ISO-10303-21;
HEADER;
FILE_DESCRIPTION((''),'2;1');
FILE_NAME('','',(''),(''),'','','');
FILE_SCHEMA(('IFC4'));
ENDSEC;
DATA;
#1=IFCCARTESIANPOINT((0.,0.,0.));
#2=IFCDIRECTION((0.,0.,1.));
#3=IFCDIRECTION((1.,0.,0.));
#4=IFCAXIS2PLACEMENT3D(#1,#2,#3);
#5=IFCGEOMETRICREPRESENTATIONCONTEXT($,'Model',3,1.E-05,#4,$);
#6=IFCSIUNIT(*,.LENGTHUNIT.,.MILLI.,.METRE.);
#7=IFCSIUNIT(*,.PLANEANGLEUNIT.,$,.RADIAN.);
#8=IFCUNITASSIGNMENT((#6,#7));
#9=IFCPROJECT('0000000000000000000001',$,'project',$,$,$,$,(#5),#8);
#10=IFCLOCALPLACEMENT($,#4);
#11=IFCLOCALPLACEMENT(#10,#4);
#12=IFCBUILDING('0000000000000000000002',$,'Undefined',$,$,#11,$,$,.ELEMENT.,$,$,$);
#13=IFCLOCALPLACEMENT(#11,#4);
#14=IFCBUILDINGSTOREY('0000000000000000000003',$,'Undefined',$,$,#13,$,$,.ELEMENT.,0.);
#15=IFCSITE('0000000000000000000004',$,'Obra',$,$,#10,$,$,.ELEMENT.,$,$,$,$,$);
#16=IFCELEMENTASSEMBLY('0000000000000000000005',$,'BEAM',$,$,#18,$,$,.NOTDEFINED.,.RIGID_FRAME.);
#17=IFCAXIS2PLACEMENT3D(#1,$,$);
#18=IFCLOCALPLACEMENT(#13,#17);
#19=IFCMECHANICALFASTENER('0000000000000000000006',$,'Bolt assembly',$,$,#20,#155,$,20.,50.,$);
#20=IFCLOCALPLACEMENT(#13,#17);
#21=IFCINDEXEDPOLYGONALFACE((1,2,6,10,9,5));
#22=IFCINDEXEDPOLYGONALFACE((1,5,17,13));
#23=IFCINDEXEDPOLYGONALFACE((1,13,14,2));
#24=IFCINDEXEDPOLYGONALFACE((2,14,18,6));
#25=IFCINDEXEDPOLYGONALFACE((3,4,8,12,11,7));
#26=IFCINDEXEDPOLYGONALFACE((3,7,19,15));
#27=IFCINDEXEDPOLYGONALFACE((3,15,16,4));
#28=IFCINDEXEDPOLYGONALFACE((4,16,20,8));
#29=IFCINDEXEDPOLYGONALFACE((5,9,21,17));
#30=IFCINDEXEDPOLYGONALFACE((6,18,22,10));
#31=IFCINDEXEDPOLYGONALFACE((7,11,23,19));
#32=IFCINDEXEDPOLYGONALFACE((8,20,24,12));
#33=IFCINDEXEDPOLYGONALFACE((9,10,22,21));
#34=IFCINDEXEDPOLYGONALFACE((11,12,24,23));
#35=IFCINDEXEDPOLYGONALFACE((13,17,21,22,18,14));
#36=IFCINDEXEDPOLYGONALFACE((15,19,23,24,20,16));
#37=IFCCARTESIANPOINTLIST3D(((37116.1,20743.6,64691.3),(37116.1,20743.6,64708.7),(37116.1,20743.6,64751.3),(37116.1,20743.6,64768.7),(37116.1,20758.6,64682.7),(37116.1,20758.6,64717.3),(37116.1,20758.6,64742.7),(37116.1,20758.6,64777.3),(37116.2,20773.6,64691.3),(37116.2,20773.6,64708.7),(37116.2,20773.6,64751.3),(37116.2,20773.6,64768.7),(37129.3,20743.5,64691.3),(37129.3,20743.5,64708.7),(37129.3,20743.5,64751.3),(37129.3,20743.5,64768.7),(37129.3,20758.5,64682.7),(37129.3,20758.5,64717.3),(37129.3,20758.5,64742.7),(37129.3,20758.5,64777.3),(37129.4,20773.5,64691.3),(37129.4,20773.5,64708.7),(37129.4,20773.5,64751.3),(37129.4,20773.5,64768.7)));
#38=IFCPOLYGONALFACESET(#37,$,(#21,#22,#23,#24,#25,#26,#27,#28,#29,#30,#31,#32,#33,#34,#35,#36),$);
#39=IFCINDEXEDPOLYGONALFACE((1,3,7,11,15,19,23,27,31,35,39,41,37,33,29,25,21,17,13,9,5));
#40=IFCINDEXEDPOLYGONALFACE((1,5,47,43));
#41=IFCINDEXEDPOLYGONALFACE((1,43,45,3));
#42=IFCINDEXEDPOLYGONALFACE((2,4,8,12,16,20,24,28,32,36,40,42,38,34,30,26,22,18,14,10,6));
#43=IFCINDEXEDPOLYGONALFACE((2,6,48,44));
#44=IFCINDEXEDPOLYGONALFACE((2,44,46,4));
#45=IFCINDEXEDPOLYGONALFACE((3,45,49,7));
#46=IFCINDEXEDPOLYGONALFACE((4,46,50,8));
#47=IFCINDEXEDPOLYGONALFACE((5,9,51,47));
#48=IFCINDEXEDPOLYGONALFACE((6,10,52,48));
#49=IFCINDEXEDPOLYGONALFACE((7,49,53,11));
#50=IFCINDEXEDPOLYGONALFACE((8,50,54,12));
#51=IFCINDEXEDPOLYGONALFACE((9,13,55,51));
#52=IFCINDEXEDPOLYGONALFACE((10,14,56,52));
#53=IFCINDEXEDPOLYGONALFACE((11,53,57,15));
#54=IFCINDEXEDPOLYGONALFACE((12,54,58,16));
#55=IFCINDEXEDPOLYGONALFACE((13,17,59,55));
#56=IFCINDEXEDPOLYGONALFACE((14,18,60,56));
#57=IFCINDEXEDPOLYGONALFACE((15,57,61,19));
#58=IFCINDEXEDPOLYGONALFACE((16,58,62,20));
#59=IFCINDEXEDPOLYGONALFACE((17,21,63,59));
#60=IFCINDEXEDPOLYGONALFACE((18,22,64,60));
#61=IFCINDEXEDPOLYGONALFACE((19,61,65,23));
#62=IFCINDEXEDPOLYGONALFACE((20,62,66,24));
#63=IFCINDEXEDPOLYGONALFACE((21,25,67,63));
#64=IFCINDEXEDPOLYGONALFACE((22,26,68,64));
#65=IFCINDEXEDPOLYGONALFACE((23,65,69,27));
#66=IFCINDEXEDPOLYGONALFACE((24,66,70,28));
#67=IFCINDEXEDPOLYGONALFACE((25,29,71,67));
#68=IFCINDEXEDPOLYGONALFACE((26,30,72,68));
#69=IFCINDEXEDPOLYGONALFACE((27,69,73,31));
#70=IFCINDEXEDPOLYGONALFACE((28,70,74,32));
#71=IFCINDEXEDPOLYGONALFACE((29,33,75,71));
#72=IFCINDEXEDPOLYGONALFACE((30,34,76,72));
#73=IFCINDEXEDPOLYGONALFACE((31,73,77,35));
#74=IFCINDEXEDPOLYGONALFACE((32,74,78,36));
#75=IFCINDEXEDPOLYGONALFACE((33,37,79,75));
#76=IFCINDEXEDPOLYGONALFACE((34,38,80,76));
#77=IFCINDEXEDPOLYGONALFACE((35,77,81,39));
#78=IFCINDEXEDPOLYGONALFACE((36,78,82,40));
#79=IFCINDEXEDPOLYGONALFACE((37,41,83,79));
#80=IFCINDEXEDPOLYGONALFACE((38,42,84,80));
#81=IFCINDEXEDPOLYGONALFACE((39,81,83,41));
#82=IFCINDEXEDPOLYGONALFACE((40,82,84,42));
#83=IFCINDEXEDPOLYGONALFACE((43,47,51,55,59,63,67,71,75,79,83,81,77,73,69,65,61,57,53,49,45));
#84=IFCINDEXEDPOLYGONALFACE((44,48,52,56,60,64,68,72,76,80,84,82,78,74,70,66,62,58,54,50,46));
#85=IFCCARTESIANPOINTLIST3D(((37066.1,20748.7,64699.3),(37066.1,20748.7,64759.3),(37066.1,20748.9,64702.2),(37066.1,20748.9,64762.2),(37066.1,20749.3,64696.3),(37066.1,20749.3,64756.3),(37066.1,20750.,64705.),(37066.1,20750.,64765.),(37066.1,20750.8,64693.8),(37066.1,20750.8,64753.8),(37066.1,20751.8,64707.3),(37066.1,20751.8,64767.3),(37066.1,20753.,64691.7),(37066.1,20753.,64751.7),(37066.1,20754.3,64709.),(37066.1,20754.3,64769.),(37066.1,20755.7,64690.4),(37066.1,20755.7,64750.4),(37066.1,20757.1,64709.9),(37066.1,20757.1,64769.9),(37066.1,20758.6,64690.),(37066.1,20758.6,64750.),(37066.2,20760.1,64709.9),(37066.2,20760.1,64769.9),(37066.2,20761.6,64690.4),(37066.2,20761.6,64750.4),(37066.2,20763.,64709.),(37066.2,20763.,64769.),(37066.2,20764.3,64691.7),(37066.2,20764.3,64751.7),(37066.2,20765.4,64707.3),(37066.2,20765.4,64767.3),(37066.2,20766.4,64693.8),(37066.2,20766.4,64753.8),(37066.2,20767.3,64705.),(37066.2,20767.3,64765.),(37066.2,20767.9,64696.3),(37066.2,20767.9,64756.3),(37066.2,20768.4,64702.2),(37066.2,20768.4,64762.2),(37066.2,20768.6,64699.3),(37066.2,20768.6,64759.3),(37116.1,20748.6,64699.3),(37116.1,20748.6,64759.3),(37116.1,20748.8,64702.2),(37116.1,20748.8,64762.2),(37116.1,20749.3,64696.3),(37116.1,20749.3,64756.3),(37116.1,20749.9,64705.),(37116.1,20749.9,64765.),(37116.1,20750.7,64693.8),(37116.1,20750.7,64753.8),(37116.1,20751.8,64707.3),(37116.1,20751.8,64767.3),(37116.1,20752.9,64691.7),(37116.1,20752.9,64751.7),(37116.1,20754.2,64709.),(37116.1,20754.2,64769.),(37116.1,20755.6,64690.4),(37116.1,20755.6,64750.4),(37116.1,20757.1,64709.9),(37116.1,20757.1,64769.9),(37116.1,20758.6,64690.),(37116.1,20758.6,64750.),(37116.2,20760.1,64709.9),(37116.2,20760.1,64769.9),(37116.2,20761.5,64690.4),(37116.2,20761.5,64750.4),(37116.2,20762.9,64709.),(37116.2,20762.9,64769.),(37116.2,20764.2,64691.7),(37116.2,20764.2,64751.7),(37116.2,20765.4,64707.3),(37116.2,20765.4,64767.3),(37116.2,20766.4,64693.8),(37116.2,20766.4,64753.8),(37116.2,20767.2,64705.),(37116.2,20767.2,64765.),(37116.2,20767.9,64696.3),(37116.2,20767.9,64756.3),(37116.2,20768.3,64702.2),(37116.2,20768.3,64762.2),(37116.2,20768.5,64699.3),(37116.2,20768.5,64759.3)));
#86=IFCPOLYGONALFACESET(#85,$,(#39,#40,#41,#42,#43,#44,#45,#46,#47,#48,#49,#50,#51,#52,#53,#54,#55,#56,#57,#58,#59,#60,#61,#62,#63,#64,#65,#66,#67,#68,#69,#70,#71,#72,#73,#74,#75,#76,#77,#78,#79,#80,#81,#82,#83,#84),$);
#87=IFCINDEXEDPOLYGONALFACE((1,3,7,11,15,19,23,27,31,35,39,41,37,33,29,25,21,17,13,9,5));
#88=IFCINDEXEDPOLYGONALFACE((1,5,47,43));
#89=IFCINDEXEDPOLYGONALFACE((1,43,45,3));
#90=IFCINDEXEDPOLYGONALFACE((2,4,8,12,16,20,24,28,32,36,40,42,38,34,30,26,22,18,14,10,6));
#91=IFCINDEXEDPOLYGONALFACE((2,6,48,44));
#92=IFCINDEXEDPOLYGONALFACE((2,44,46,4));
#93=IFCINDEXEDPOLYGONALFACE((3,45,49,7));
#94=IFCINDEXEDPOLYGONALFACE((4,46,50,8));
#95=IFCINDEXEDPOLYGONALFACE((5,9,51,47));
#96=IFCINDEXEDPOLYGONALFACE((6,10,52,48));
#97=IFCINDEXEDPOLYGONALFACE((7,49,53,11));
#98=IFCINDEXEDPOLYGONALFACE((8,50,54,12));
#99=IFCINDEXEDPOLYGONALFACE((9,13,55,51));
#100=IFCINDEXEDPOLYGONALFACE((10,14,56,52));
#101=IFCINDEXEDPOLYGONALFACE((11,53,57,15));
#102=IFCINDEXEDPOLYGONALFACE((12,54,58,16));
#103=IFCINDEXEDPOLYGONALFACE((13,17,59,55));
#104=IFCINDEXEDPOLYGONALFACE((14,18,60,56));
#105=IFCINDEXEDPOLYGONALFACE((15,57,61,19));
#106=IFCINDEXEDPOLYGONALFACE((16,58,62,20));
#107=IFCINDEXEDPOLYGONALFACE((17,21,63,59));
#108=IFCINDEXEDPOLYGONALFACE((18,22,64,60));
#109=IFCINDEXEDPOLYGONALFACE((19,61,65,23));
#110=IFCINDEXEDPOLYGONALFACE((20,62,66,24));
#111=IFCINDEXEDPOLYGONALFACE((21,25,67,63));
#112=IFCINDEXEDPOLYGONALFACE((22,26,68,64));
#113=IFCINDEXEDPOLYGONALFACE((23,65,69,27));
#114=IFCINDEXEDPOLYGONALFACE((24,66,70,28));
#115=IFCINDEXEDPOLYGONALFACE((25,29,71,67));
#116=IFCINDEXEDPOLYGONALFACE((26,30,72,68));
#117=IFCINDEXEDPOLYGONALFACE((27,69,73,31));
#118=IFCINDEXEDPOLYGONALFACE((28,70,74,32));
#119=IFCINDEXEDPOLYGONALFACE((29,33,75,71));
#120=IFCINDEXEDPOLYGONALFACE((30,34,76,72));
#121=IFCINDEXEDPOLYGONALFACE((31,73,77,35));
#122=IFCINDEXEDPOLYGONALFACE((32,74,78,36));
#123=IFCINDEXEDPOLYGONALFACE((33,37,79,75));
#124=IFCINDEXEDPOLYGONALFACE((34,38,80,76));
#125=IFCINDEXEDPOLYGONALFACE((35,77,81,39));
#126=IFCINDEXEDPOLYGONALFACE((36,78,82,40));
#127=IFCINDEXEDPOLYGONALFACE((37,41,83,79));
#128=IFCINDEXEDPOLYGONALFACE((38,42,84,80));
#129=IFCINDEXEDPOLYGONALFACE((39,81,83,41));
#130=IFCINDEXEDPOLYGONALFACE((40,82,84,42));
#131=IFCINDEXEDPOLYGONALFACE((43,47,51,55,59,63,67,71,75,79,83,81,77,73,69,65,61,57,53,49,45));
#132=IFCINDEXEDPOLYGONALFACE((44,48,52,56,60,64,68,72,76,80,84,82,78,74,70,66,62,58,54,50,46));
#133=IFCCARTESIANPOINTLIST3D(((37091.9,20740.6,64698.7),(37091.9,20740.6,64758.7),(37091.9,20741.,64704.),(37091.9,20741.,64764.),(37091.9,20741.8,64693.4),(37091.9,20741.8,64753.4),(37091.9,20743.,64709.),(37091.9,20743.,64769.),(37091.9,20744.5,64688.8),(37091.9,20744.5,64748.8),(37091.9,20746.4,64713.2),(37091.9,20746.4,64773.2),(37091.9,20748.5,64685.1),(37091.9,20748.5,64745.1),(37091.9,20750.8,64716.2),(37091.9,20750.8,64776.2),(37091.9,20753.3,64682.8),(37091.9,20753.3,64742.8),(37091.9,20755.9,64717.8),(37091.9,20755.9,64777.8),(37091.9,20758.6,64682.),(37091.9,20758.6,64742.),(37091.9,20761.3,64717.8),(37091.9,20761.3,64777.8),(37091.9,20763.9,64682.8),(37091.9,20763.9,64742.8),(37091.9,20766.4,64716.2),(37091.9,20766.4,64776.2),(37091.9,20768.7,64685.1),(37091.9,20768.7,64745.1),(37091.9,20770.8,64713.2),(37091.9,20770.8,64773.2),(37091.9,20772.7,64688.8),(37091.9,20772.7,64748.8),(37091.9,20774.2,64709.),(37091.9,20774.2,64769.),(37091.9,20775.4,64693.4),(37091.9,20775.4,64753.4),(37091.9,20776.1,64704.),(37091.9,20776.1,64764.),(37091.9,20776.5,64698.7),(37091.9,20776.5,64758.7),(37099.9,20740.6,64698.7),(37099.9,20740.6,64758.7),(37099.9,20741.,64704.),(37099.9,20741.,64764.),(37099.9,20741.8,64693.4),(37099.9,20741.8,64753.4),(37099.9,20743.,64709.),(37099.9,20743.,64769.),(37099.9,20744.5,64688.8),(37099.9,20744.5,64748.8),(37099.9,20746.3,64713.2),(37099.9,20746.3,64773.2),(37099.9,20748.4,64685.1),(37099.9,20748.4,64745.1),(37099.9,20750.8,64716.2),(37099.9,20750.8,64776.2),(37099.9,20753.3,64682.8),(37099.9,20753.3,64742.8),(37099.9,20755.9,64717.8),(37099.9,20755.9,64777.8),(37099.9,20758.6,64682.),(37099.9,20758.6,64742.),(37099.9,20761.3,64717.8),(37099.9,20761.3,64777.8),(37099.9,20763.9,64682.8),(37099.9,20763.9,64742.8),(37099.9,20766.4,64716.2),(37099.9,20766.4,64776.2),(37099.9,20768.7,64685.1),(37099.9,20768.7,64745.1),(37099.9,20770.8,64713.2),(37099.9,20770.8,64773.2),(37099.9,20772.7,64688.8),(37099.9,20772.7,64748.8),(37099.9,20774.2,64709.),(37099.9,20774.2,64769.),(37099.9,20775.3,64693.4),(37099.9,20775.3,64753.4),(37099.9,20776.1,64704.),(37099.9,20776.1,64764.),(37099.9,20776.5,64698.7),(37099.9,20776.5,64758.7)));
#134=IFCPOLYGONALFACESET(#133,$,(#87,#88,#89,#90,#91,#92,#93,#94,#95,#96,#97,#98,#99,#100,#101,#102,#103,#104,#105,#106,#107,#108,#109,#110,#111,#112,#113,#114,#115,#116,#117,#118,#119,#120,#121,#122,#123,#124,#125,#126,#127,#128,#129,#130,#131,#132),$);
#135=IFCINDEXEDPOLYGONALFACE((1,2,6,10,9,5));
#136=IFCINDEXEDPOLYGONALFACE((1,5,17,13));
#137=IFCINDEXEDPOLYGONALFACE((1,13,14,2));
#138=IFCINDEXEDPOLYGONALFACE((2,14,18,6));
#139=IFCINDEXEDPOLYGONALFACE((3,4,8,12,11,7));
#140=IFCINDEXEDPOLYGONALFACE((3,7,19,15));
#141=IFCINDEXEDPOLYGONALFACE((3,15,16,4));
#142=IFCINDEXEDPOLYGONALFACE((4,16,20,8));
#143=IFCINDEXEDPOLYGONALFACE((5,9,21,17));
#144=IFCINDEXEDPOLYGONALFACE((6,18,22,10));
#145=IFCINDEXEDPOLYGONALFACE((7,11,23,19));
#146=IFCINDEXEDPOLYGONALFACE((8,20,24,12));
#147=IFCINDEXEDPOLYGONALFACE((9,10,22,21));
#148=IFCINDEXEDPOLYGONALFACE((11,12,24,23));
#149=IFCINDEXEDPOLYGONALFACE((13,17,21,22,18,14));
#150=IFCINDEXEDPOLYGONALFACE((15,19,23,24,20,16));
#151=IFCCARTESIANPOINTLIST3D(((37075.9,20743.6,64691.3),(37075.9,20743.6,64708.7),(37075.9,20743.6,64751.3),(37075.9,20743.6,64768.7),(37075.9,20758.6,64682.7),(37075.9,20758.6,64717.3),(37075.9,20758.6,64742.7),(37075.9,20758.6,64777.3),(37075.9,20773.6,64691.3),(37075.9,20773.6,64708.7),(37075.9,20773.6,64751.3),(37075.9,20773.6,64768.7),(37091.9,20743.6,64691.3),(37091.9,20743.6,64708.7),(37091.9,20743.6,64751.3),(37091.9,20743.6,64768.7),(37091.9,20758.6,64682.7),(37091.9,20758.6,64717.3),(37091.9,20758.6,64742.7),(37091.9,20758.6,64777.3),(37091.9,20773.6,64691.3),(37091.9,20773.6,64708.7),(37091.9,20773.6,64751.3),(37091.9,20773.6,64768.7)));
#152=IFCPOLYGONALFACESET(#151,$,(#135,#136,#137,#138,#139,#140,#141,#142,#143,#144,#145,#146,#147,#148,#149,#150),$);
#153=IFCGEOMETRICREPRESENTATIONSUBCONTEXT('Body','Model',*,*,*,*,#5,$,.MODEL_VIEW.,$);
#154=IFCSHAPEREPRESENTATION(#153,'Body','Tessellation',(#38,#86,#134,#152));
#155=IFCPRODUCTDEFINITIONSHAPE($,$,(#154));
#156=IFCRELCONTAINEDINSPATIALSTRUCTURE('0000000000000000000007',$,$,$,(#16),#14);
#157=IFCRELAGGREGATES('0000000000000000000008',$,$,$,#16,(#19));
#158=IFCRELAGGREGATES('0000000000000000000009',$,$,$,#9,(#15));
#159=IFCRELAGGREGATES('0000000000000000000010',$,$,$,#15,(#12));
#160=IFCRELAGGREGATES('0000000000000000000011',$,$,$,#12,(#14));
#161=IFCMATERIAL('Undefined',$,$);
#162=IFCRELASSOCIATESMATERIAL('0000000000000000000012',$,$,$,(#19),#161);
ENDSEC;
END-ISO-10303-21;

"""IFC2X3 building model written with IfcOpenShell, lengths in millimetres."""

from ifc_helpers import new_model, si_unit, frame, origin_with_axes, origin_2d_with_axis, place, context, subcontext, project, spatial, polyline, circle, outline, extrude, source, transform, mapped, material, element, aggregate, save


model = new_model("IFC2X3")

# Units and contexts
model_context = context("Model", 3, precision=1e-05, world=origin_with_axes())
body_context = subcontext(model_context, "Body", "Model", "MODEL_VIEW")
ifc_project = project(units=[si_unit("LENGTHUNIT", "METRE", prefix="MILLI"), si_unit("PLANEANGLEUNIT", "RADIAN")], contexts=[model_context])

# Site, building, storey
site_placement = place(None, origin_with_axes())
site = spatial("IfcSite", under=ifc_project, at=site_placement, Name="Obra", CompositionType="ELEMENT")
building_placement = place(site_placement, origin_with_axes())
building = spatial("IfcBuilding", under=site, at=building_placement, Name="Undefined", CompositionType="ELEMENT")
storey_placement = place(building_placement, origin_with_axes())
storey = spatial("IfcBuildingStorey", under=building, at=storey_placement, Name="Undefined", CompositionType="ELEMENT", Elevation=0.0)

# Shared definitions
ifc_material = material(Name="Undefined")

# Element assembly
assembly_1_placement = place(storey_placement, origin_with_axes())
assembly_1 = element("IfcElementAssembly", 1, at=assembly_1_placement, inside=storey, Name="BEAM", AssemblyPlace="NOTDEFINED", PredefinedType="RIGID_FRAME")

# Mechanical fastener
shared_shape_1 = source(origin_with_axes(), body_context, "Body", "SweptSolid", [
    extrude(outline(polyline([(17.3, 0.0), (8.7, 15.0), (-8.7, 15.0), (-17.3, 0.0), (-8.7, -15.0), (8.7, -15.0), (17.3, 0.0)])), frame((0.0, -26.3, 0.0), z_axis=(0.0, 1.0, 0.0), x_axis=(1.0, 0.0, 0.0)), (0.0, 0.0, 1.0), 13.2),
    extrude(circle(Radius=10.0, at=origin_2d_with_axis()), frame((0.0, -13.1, 0.0), z_axis=(0.0, 1.0, 0.0), x_axis=(1.0, 0.0, 0.0)), (0.0, 0.0, 1.0), 50.0),
    extrude(circle(Radius=18.0, at=origin_2d_with_axis()), frame((0.0, 3.1, 0.0), z_axis=(0.0, 1.0, 0.0), x_axis=(1.0, 0.0, 0.0)), (0.0, 0.0, 1.0), 8.0),
    extrude(outline(polyline([(17.3, 0.0), (8.7, 15.0), (-8.7, 15.0), (-17.3, 0.0), (-8.7, -15.0), (8.7, -15.0), (17.3, 0.0)])), frame((0.0, 11.1, 0.0), z_axis=(0.0, 1.0, 0.0), x_axis=(1.0, 0.0, 0.0)), (0.0, 0.0, 1.0), 16.0),
])
mechanical_fastener_1_placement = place(assembly_1_placement, frame((37103.0, 20718.6, 64850.0), z_axis=(0.001435, 0.999999, 0.0), x_axis=(0.0, 0.0, -1.0)))
mechanical_fastener_1 = element("IfcMechanicalFastener", 2, at=mechanical_fastener_1_placement, material=ifc_material, Name="Bolt assembly", NominalDiameter=20.0, NominalLength=50.0, context=body_context, shape_type="MappedRepresentation", body=[
    mapped(shared_shape_1, transform((90.0, 0.0, 40.0))),
    mapped(shared_shape_1, transform((150.0, 0.0, 40.0))),
])
aggregate(assembly_1, [mechanical_fastener_1])

save(model, "model.ifc")
